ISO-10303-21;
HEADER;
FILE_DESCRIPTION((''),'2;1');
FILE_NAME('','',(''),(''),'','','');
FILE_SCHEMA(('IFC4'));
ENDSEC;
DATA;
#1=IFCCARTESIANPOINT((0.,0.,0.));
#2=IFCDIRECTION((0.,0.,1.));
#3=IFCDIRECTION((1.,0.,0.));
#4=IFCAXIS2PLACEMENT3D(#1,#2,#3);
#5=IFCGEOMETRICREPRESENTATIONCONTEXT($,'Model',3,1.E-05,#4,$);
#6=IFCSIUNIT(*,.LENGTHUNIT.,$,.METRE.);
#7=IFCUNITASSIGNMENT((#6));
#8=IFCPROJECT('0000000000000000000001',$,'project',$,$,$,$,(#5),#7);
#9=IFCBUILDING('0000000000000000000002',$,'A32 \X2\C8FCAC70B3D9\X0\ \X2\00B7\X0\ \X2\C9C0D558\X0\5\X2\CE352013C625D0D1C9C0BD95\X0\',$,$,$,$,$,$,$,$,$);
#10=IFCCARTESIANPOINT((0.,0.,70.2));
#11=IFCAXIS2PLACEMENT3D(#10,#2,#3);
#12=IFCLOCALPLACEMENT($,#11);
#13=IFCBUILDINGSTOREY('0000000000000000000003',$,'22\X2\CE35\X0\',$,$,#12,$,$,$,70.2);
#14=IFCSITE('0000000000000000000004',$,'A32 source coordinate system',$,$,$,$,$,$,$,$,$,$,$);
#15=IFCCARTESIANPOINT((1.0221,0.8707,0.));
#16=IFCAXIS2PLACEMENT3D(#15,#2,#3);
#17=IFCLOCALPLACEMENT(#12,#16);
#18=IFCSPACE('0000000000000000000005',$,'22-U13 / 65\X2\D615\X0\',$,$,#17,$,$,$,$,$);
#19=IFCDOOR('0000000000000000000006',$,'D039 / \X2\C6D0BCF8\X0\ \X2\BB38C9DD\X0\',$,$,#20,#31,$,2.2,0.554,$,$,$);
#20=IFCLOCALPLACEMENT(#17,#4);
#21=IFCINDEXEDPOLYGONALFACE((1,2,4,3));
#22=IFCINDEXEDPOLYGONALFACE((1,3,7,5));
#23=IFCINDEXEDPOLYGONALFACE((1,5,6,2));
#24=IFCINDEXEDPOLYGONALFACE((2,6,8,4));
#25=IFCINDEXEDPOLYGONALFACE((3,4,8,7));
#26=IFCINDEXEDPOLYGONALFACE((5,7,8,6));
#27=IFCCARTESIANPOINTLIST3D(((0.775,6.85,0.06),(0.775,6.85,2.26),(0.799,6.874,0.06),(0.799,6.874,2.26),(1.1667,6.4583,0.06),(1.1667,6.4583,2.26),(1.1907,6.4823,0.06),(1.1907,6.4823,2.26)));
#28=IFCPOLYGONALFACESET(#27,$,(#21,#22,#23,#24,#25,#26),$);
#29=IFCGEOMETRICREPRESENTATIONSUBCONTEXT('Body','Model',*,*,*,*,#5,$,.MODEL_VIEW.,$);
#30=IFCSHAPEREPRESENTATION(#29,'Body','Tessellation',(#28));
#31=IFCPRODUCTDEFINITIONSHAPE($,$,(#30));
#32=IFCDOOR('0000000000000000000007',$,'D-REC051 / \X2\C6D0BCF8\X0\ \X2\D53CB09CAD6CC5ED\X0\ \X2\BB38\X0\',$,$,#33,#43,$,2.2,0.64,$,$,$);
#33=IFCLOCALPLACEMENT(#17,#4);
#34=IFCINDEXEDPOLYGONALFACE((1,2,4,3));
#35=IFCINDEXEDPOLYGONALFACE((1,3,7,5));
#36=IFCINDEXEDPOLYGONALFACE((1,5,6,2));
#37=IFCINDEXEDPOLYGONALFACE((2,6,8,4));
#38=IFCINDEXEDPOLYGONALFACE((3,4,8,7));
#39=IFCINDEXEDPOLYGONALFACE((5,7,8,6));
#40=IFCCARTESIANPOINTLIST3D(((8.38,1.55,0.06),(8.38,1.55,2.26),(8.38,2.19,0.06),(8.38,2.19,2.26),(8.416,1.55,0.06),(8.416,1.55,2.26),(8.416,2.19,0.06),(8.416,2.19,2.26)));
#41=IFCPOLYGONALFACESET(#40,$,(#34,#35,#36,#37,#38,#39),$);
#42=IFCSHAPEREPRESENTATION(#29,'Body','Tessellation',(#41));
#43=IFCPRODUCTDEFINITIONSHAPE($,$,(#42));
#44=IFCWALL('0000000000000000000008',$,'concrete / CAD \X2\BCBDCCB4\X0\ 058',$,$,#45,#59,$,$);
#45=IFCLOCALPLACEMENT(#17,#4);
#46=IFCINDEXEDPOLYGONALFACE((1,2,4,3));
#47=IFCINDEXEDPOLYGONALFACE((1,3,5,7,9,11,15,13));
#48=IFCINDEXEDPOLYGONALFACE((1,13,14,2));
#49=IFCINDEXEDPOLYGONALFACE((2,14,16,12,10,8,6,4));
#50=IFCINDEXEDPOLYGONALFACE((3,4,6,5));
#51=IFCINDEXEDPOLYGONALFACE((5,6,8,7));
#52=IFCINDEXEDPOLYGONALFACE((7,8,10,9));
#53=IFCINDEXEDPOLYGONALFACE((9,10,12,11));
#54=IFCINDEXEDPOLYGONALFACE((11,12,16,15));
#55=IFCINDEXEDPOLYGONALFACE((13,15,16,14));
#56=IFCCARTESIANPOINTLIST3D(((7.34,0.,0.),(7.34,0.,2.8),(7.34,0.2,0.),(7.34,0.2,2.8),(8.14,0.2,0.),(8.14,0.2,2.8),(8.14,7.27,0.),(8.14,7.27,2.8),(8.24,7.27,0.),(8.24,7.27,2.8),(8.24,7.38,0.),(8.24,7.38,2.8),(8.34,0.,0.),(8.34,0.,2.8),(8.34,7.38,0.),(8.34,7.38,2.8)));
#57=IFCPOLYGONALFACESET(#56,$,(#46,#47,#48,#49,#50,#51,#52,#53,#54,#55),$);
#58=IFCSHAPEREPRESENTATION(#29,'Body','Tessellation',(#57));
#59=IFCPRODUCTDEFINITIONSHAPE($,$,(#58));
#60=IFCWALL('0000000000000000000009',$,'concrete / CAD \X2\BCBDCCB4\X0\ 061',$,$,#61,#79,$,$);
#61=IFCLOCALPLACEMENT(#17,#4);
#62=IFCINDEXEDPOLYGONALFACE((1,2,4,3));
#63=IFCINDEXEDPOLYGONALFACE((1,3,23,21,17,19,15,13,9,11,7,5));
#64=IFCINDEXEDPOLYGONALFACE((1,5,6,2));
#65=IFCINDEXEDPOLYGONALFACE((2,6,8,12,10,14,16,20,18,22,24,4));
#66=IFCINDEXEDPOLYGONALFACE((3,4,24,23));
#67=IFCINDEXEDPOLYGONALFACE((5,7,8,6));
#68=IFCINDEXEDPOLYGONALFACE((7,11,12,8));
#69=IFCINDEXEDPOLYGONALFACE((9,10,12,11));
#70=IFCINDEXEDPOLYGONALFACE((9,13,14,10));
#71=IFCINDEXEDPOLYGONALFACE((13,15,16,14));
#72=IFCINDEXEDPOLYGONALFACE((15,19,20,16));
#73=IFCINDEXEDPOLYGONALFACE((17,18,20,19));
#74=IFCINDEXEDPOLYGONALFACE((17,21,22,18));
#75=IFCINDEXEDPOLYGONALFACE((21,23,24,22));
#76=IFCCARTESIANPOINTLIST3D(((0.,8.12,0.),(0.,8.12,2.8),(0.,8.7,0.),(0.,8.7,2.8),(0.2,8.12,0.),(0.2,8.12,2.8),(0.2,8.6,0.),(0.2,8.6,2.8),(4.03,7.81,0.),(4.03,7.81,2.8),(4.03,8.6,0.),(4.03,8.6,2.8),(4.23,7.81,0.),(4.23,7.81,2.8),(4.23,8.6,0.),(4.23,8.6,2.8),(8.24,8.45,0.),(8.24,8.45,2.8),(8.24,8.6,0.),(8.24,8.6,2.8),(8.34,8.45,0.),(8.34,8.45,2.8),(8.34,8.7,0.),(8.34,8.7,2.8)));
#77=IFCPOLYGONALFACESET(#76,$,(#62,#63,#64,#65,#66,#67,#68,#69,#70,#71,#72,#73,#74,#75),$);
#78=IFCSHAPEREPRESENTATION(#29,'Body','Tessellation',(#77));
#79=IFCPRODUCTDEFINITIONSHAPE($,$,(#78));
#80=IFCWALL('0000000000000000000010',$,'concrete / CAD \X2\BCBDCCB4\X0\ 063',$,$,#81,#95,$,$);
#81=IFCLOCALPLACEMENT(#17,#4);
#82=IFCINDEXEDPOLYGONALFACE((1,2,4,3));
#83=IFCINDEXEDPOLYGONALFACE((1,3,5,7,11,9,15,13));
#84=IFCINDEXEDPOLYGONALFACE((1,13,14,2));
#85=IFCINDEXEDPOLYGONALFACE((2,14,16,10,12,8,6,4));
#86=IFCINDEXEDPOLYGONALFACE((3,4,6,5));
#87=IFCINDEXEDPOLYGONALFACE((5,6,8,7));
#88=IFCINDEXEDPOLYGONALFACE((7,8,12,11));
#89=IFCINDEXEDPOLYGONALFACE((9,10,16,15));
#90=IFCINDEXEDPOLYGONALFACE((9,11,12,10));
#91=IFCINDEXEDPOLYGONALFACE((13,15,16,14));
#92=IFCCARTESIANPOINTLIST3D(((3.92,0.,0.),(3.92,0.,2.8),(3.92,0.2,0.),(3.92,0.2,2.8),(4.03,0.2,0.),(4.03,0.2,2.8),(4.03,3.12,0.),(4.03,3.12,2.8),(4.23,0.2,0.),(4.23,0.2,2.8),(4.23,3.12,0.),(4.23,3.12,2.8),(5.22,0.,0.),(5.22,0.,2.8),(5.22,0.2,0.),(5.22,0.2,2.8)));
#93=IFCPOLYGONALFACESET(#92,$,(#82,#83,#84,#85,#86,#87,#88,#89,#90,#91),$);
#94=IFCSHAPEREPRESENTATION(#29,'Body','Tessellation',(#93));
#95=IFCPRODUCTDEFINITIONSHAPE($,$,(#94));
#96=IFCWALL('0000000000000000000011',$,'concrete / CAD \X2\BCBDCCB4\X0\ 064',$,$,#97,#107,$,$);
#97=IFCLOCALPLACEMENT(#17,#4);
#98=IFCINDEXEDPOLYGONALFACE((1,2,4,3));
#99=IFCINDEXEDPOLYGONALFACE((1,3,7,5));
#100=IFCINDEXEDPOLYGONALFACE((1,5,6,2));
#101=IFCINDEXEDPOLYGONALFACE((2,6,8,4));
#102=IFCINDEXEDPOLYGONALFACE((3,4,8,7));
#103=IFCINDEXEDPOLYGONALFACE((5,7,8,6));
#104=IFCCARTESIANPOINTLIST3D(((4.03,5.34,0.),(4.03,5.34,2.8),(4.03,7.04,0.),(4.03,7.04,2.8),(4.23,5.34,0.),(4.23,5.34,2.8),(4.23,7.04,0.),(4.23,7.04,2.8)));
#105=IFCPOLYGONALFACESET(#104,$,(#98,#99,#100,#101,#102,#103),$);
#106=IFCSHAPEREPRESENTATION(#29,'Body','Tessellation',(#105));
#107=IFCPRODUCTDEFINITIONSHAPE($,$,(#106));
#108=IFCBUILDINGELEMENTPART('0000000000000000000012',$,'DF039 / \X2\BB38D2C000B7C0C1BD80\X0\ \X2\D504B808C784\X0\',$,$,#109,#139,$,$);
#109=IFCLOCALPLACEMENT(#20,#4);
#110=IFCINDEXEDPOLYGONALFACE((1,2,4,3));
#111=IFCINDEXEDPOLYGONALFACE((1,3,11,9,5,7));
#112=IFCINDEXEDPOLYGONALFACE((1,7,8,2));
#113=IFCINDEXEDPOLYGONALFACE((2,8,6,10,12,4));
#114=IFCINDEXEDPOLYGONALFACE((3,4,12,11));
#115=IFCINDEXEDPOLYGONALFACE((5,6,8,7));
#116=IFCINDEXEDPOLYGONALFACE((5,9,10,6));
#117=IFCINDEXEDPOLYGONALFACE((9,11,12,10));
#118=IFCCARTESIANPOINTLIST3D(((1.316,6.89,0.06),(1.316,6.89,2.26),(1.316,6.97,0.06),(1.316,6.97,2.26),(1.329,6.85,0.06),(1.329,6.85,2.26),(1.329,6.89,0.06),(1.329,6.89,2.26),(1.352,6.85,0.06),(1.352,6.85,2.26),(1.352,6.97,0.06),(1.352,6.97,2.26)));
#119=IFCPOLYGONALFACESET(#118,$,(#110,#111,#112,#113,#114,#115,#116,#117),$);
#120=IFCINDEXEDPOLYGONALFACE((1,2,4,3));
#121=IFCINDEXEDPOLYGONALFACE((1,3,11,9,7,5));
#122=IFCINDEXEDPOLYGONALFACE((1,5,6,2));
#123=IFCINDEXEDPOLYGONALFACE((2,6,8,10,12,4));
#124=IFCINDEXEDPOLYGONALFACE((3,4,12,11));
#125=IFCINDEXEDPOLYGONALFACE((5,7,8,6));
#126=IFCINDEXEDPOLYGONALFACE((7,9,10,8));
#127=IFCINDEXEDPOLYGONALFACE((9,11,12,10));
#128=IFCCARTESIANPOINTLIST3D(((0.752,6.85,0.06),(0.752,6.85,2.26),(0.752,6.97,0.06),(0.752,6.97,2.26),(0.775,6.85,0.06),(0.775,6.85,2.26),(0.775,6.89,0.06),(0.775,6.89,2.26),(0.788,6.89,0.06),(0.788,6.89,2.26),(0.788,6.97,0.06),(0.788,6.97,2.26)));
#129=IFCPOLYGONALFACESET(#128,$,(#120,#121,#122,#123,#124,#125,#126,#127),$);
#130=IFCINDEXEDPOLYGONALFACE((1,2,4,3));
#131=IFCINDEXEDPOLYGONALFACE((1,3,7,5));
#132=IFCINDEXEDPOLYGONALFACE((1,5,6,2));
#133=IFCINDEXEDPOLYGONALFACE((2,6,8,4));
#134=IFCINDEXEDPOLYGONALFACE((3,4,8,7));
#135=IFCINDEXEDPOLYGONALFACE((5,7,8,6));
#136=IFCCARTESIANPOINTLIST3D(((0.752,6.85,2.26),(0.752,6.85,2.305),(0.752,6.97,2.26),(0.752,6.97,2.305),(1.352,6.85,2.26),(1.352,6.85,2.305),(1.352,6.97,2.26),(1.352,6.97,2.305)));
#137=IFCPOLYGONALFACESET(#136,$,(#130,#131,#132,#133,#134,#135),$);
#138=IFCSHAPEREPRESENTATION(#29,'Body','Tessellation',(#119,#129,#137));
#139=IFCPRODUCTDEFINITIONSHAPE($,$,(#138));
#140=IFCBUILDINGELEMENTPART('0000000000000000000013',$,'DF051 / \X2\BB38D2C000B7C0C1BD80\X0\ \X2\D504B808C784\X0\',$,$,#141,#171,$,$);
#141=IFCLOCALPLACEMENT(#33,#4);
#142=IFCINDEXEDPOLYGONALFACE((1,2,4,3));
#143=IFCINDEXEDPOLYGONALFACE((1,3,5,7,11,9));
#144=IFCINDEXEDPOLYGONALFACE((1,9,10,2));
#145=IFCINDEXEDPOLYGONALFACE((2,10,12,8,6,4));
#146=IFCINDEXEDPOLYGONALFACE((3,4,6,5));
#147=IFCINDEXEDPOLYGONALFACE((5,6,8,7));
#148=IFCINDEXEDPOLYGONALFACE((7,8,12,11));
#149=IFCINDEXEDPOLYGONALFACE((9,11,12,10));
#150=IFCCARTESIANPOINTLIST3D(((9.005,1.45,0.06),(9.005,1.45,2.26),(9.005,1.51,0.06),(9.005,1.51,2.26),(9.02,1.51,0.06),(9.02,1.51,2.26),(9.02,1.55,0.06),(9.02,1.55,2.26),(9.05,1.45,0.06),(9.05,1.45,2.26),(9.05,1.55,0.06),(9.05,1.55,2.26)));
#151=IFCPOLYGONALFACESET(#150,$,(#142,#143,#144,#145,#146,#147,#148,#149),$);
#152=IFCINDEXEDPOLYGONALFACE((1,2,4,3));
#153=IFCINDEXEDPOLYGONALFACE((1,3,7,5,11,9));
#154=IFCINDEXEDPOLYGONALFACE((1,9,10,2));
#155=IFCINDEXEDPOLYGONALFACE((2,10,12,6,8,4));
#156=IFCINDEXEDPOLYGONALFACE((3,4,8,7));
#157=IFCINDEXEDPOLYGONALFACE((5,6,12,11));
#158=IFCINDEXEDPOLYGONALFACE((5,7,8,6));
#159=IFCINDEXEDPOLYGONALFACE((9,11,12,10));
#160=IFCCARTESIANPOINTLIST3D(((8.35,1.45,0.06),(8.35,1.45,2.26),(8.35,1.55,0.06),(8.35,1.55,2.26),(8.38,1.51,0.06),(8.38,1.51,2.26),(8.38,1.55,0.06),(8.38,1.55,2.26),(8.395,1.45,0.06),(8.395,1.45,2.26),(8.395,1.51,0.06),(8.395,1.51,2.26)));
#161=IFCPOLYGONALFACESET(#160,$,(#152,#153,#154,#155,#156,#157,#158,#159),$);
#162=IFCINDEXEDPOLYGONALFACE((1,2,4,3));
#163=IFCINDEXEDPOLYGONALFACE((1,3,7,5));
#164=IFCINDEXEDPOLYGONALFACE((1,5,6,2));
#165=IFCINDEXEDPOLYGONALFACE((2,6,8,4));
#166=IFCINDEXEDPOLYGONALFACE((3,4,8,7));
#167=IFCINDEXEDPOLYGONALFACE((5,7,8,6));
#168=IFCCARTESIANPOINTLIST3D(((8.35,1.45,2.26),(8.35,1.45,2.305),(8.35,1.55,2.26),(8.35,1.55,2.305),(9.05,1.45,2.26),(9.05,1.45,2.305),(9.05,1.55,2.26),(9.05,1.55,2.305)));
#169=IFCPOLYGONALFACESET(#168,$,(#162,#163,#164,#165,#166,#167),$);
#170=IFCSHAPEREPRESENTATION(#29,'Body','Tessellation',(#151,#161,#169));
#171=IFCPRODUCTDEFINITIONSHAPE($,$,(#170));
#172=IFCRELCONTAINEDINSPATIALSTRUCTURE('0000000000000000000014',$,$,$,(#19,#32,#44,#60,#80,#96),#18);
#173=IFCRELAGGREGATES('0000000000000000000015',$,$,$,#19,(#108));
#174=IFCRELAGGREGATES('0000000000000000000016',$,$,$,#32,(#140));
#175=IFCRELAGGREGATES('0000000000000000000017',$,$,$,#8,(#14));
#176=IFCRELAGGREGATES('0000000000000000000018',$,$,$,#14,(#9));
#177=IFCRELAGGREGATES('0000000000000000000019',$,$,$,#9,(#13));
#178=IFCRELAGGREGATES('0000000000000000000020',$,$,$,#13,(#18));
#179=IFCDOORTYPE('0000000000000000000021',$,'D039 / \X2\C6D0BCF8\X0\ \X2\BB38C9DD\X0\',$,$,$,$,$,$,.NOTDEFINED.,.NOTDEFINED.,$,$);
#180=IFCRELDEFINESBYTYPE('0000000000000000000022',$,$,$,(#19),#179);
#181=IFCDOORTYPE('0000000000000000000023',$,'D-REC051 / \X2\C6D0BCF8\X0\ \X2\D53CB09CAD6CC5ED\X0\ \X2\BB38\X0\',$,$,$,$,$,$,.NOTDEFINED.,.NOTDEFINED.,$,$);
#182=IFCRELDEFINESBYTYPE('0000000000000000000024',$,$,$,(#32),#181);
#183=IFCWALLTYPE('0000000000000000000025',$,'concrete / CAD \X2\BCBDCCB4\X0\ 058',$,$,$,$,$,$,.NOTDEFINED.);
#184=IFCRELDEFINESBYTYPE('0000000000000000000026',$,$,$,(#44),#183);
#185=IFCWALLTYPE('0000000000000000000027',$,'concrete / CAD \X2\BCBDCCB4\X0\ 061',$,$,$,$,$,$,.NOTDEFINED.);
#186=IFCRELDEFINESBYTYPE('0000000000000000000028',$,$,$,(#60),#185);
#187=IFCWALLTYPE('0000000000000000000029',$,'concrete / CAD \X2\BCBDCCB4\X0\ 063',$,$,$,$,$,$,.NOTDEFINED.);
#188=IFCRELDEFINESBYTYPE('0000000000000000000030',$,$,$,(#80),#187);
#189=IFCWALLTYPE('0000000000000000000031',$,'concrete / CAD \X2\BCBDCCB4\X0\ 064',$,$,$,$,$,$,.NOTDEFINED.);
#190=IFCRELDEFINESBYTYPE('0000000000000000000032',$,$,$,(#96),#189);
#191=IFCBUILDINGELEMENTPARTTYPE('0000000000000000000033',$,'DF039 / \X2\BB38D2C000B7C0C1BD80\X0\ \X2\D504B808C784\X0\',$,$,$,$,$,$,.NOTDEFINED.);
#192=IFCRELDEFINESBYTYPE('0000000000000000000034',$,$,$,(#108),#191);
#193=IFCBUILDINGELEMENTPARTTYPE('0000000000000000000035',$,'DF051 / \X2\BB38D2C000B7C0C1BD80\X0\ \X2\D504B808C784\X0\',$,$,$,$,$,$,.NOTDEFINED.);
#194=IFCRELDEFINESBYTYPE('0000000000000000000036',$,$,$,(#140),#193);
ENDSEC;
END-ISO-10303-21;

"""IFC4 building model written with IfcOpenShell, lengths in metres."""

from ifc_helpers import new_model, si_unit, frame, origin, origin_with_axes, place, context, subcontext, project, spatial, polyline, outline, extrude, source, transform, mapped, type_object, type_shapes, element, aggregate, save


model = new_model("IFC4")

# Units and contexts
model_context = context("Model", 3, precision=1e-05, world=origin_with_axes())
body_context = subcontext(model_context, "Body", "Model", "MODEL_VIEW")
ifc_project = project(units=[si_unit("LENGTHUNIT", "METRE")], contexts=[model_context])

# Site, building, storey, space
storey_placement = place(None, frame((0.0, 0.0, 70.2), z_axis=(0.0, 0.0, 1.0), x_axis=(1.0, 0.0, 0.0)))
space_placement = place(storey_placement, frame((1.0221, 0.8707, 0.0), z_axis=(0.0, 0.0, 1.0), x_axis=(1.0, 0.0, 0.0)))
site = spatial("IfcSite", under=ifc_project, Name="A32 source coordinate system")
building = spatial("IfcBuilding", under=site, Name="A32 주거동 · 지하5층–옥탑지붕")
storey = spatial("IfcBuildingStorey", under=building, at=storey_placement, Name="22층", Elevation=70.2)
space = spatial("IfcSpace", under=storey, at=space_placement, Name="22-U13 / 65형")

# Doors
door_type_1 = type_object("IfcDoorType", Name="D039 / 원본 문짝", OperationType="NOTDEFINED", PredefinedType="NOTDEFINED")
shared_shape_1 = source(origin(), body_context, "Body", "SweptSolid", [
    extrude(outline(polyline([(1.1907, 6.4823), (1.1667, 6.4583), (0.775, 6.85), (0.799, 6.874), (1.1907, 6.4823)])), frame((0.0, 0.0, 0.06)), (0.0, 0.0, 1.0), 2.2),
])
type_shapes(door_type_1, [shared_shape_1])
door_1_placement = place(space_placement, origin_with_axes())
door_1 = element("IfcDoor", 1, at=door_1_placement, inside=space, type_object=door_type_1, Name="D039 / 원본 문짝", OverallHeight=2.2, OverallWidth=0.554, context=body_context, shape_type="MappedRepresentation", body=[
    mapped(shared_shape_1, transform((0.0, 0.0, 0.0), scale=1.0)),
])
door_type_2 = type_object("IfcDoorType", Name="D-REC051 / 원본 피난구역 문", OperationType="NOTDEFINED", PredefinedType="NOTDEFINED")
shared_shape_2 = source(origin(), body_context, "Body", "SweptSolid", [
    extrude(outline(polyline([(8.416, 2.19), (8.416, 1.55), (8.38, 1.55), (8.38, 2.19), (8.416, 2.19)])), frame((0.0, 0.0, 0.06)), (0.0, 0.0, 1.0), 2.2),
])
type_shapes(door_type_2, [shared_shape_2])
door_2_placement = place(space_placement, origin_with_axes())
door_2 = element("IfcDoor", 2, at=door_2_placement, inside=space, type_object=door_type_2, Name="D-REC051 / 원본 피난구역 문", OverallHeight=2.2, OverallWidth=0.64, context=body_context, shape_type="MappedRepresentation", body=[
    mapped(shared_shape_2, transform((0.0, 0.0, 0.0), scale=1.0)),
])

# Walls
wall_type_1 = type_object("IfcWallType", Name="concrete / CAD 벽체 058", PredefinedType="NOTDEFINED")
shared_shape_3 = source(origin(), body_context, "Body", "SweptSolid", [
    extrude(outline(polyline([(8.34, 0.0), (7.34, 0.0), (7.34, 0.2), (8.14, 0.2), (8.14, 7.27), (8.24, 7.27), (8.24, 7.38), (8.34, 7.38), (8.34, 0.0)])), origin(), (0.0, 0.0, 1.0), 2.8),
])
type_shapes(wall_type_1, [shared_shape_3])
wall_1_placement = place(space_placement, origin_with_axes())
element("IfcWall", 3, at=wall_1_placement, inside=space, type_object=wall_type_1, Name="concrete / CAD 벽체 058", context=body_context, shape_type="MappedRepresentation", body=[
    mapped(shared_shape_3, transform((0.0, 0.0, 0.0), scale=1.0)),
])
wall_type_2 = type_object("IfcWallType", Name="concrete / CAD 벽체 061", PredefinedType="NOTDEFINED")
shared_shape_4 = source(origin(), body_context, "Body", "SweptSolid", [
    extrude(outline(polyline([(0.2, 8.6), (0.2, 8.12), (0.0, 8.12), (0.0, 8.7), (8.34, 8.7), (8.34, 8.45), (8.24, 8.45), (8.24, 8.6), (4.23, 8.6), (4.23, 7.81), (4.03, 7.81), (4.03, 8.6), (0.2, 8.6)])), origin(), (0.0, 0.0, 1.0), 2.8),
])
type_shapes(wall_type_2, [shared_shape_4])
wall_2_placement = place(space_placement, origin_with_axes())
element("IfcWall", 4, at=wall_2_placement, inside=space, type_object=wall_type_2, Name="concrete / CAD 벽체 061", context=body_context, shape_type="MappedRepresentation", body=[
    mapped(shared_shape_4, transform((0.0, 0.0, 0.0), scale=1.0)),
])
wall_type_3 = type_object("IfcWallType", Name="concrete / CAD 벽체 063", PredefinedType="NOTDEFINED")
shared_shape_5 = source(origin(), body_context, "Body", "SweptSolid", [
    extrude(outline(polyline([(5.22, 0.0), (3.92, 0.0), (3.92, 0.2), (4.03, 0.2), (4.03, 3.12), (4.23, 3.12), (4.23, 0.2), (5.22, 0.2), (5.22, 0.0)])), origin(), (0.0, 0.0, 1.0), 2.8),
])
type_shapes(wall_type_3, [shared_shape_5])
wall_3_placement = place(space_placement, origin_with_axes())
element("IfcWall", 5, at=wall_3_placement, inside=space, type_object=wall_type_3, Name="concrete / CAD 벽체 063", context=body_context, shape_type="MappedRepresentation", body=[
    mapped(shared_shape_5, transform((0.0, 0.0, 0.0), scale=1.0)),
])
wall_type_4 = type_object("IfcWallType", Name="concrete / CAD 벽체 064", PredefinedType="NOTDEFINED")
shared_shape_6 = source(origin(), body_context, "Body", "SweptSolid", [
    extrude(outline(polyline([(4.03, 7.04), (4.23, 7.04), (4.23, 5.34), (4.03, 5.34), (4.03, 7.04)])), origin(), (0.0, 0.0, 1.0), 2.8),
])
type_shapes(wall_type_4, [shared_shape_6])
wall_4_placement = place(space_placement, origin_with_axes())
element("IfcWall", 6, at=wall_4_placement, inside=space, type_object=wall_type_4, Name="concrete / CAD 벽체 064", context=body_context, shape_type="MappedRepresentation", body=[
    mapped(shared_shape_6, transform((0.0, 0.0, 0.0), scale=1.0)),
])

# Building element parts
building_element_part_type_1 = type_object("IfcBuildingElementPartType", Name="DF039 / 문틀·상부 프레임", PredefinedType="NOTDEFINED")
shared_shape_7 = source(origin(), body_context, "Body", "SweptSolid", [
    extrude(outline(polyline([(1.352, 6.85), (1.329, 6.85), (1.329, 6.89), (1.316, 6.89), (1.316, 6.97), (1.352, 6.97), (1.352, 6.85)])), frame((0.0, 0.0, 0.06)), (0.0, 0.0, 1.0), 2.2),
    extrude(outline(polyline([(0.788, 6.97), (0.788, 6.89), (0.775, 6.89), (0.775, 6.85), (0.752, 6.85), (0.752, 6.97), (0.788, 6.97)])), frame((0.0, 0.0, 0.06)), (0.0, 0.0, 1.0), 2.2),
    extrude(outline(polyline([(0.752, 6.85), (0.752, 6.97), (1.352, 6.97), (1.352, 6.85), (0.752, 6.85)])), frame((0.0, 0.0, 2.26)), (0.0, 0.0, 1.0), 0.045),
])
type_shapes(building_element_part_type_1, [shared_shape_7])
building_element_part_1_placement = place(door_1_placement, origin_with_axes())
building_element_part_1 = element("IfcBuildingElementPart", 7, at=building_element_part_1_placement, type_object=building_element_part_type_1, Name="DF039 / 문틀·상부 프레임", context=body_context, shape_type="MappedRepresentation", body=[
    mapped(shared_shape_7, transform((0.0, 0.0, 0.0), scale=1.0)),
])
aggregate(door_1, [building_element_part_1])
building_element_part_type_2 = type_object("IfcBuildingElementPartType", Name="DF051 / 문틀·상부 프레임", PredefinedType="NOTDEFINED")
shared_shape_8 = source(origin(), body_context, "Body", "SweptSolid", [
    extrude(outline(polyline([(9.05, 1.45), (9.005, 1.45), (9.005, 1.51), (9.02, 1.51), (9.02, 1.55), (9.05, 1.55), (9.05, 1.45)])), frame((0.0, 0.0, 0.06)), (0.0, 0.0, 1.0), 2.2),
    extrude(outline(polyline([(8.38, 1.55), (8.38, 1.51), (8.395, 1.51), (8.395, 1.45), (8.35, 1.45), (8.35, 1.55), (8.38, 1.55)])), frame((0.0, 0.0, 0.06)), (0.0, 0.0, 1.0), 2.2),
    extrude(outline(polyline([(8.35, 1.45), (8.35, 1.55), (9.05, 1.55), (9.05, 1.45), (8.35, 1.45)])), frame((0.0, 0.0, 2.26)), (0.0, 0.0, 1.0), 0.045),
])
type_shapes(building_element_part_type_2, [shared_shape_8])
building_element_part_2_placement = place(door_2_placement, origin_with_axes())
building_element_part_2 = element("IfcBuildingElementPart", 8, at=building_element_part_2_placement, type_object=building_element_part_type_2, Name="DF051 / 문틀·상부 프레임", context=body_context, shape_type="MappedRepresentation", body=[
    mapped(shared_shape_8, transform((0.0, 0.0, 0.0), scale=1.0)),
])
aggregate(door_2, [building_element_part_2])

save(model, "model.ifc")
